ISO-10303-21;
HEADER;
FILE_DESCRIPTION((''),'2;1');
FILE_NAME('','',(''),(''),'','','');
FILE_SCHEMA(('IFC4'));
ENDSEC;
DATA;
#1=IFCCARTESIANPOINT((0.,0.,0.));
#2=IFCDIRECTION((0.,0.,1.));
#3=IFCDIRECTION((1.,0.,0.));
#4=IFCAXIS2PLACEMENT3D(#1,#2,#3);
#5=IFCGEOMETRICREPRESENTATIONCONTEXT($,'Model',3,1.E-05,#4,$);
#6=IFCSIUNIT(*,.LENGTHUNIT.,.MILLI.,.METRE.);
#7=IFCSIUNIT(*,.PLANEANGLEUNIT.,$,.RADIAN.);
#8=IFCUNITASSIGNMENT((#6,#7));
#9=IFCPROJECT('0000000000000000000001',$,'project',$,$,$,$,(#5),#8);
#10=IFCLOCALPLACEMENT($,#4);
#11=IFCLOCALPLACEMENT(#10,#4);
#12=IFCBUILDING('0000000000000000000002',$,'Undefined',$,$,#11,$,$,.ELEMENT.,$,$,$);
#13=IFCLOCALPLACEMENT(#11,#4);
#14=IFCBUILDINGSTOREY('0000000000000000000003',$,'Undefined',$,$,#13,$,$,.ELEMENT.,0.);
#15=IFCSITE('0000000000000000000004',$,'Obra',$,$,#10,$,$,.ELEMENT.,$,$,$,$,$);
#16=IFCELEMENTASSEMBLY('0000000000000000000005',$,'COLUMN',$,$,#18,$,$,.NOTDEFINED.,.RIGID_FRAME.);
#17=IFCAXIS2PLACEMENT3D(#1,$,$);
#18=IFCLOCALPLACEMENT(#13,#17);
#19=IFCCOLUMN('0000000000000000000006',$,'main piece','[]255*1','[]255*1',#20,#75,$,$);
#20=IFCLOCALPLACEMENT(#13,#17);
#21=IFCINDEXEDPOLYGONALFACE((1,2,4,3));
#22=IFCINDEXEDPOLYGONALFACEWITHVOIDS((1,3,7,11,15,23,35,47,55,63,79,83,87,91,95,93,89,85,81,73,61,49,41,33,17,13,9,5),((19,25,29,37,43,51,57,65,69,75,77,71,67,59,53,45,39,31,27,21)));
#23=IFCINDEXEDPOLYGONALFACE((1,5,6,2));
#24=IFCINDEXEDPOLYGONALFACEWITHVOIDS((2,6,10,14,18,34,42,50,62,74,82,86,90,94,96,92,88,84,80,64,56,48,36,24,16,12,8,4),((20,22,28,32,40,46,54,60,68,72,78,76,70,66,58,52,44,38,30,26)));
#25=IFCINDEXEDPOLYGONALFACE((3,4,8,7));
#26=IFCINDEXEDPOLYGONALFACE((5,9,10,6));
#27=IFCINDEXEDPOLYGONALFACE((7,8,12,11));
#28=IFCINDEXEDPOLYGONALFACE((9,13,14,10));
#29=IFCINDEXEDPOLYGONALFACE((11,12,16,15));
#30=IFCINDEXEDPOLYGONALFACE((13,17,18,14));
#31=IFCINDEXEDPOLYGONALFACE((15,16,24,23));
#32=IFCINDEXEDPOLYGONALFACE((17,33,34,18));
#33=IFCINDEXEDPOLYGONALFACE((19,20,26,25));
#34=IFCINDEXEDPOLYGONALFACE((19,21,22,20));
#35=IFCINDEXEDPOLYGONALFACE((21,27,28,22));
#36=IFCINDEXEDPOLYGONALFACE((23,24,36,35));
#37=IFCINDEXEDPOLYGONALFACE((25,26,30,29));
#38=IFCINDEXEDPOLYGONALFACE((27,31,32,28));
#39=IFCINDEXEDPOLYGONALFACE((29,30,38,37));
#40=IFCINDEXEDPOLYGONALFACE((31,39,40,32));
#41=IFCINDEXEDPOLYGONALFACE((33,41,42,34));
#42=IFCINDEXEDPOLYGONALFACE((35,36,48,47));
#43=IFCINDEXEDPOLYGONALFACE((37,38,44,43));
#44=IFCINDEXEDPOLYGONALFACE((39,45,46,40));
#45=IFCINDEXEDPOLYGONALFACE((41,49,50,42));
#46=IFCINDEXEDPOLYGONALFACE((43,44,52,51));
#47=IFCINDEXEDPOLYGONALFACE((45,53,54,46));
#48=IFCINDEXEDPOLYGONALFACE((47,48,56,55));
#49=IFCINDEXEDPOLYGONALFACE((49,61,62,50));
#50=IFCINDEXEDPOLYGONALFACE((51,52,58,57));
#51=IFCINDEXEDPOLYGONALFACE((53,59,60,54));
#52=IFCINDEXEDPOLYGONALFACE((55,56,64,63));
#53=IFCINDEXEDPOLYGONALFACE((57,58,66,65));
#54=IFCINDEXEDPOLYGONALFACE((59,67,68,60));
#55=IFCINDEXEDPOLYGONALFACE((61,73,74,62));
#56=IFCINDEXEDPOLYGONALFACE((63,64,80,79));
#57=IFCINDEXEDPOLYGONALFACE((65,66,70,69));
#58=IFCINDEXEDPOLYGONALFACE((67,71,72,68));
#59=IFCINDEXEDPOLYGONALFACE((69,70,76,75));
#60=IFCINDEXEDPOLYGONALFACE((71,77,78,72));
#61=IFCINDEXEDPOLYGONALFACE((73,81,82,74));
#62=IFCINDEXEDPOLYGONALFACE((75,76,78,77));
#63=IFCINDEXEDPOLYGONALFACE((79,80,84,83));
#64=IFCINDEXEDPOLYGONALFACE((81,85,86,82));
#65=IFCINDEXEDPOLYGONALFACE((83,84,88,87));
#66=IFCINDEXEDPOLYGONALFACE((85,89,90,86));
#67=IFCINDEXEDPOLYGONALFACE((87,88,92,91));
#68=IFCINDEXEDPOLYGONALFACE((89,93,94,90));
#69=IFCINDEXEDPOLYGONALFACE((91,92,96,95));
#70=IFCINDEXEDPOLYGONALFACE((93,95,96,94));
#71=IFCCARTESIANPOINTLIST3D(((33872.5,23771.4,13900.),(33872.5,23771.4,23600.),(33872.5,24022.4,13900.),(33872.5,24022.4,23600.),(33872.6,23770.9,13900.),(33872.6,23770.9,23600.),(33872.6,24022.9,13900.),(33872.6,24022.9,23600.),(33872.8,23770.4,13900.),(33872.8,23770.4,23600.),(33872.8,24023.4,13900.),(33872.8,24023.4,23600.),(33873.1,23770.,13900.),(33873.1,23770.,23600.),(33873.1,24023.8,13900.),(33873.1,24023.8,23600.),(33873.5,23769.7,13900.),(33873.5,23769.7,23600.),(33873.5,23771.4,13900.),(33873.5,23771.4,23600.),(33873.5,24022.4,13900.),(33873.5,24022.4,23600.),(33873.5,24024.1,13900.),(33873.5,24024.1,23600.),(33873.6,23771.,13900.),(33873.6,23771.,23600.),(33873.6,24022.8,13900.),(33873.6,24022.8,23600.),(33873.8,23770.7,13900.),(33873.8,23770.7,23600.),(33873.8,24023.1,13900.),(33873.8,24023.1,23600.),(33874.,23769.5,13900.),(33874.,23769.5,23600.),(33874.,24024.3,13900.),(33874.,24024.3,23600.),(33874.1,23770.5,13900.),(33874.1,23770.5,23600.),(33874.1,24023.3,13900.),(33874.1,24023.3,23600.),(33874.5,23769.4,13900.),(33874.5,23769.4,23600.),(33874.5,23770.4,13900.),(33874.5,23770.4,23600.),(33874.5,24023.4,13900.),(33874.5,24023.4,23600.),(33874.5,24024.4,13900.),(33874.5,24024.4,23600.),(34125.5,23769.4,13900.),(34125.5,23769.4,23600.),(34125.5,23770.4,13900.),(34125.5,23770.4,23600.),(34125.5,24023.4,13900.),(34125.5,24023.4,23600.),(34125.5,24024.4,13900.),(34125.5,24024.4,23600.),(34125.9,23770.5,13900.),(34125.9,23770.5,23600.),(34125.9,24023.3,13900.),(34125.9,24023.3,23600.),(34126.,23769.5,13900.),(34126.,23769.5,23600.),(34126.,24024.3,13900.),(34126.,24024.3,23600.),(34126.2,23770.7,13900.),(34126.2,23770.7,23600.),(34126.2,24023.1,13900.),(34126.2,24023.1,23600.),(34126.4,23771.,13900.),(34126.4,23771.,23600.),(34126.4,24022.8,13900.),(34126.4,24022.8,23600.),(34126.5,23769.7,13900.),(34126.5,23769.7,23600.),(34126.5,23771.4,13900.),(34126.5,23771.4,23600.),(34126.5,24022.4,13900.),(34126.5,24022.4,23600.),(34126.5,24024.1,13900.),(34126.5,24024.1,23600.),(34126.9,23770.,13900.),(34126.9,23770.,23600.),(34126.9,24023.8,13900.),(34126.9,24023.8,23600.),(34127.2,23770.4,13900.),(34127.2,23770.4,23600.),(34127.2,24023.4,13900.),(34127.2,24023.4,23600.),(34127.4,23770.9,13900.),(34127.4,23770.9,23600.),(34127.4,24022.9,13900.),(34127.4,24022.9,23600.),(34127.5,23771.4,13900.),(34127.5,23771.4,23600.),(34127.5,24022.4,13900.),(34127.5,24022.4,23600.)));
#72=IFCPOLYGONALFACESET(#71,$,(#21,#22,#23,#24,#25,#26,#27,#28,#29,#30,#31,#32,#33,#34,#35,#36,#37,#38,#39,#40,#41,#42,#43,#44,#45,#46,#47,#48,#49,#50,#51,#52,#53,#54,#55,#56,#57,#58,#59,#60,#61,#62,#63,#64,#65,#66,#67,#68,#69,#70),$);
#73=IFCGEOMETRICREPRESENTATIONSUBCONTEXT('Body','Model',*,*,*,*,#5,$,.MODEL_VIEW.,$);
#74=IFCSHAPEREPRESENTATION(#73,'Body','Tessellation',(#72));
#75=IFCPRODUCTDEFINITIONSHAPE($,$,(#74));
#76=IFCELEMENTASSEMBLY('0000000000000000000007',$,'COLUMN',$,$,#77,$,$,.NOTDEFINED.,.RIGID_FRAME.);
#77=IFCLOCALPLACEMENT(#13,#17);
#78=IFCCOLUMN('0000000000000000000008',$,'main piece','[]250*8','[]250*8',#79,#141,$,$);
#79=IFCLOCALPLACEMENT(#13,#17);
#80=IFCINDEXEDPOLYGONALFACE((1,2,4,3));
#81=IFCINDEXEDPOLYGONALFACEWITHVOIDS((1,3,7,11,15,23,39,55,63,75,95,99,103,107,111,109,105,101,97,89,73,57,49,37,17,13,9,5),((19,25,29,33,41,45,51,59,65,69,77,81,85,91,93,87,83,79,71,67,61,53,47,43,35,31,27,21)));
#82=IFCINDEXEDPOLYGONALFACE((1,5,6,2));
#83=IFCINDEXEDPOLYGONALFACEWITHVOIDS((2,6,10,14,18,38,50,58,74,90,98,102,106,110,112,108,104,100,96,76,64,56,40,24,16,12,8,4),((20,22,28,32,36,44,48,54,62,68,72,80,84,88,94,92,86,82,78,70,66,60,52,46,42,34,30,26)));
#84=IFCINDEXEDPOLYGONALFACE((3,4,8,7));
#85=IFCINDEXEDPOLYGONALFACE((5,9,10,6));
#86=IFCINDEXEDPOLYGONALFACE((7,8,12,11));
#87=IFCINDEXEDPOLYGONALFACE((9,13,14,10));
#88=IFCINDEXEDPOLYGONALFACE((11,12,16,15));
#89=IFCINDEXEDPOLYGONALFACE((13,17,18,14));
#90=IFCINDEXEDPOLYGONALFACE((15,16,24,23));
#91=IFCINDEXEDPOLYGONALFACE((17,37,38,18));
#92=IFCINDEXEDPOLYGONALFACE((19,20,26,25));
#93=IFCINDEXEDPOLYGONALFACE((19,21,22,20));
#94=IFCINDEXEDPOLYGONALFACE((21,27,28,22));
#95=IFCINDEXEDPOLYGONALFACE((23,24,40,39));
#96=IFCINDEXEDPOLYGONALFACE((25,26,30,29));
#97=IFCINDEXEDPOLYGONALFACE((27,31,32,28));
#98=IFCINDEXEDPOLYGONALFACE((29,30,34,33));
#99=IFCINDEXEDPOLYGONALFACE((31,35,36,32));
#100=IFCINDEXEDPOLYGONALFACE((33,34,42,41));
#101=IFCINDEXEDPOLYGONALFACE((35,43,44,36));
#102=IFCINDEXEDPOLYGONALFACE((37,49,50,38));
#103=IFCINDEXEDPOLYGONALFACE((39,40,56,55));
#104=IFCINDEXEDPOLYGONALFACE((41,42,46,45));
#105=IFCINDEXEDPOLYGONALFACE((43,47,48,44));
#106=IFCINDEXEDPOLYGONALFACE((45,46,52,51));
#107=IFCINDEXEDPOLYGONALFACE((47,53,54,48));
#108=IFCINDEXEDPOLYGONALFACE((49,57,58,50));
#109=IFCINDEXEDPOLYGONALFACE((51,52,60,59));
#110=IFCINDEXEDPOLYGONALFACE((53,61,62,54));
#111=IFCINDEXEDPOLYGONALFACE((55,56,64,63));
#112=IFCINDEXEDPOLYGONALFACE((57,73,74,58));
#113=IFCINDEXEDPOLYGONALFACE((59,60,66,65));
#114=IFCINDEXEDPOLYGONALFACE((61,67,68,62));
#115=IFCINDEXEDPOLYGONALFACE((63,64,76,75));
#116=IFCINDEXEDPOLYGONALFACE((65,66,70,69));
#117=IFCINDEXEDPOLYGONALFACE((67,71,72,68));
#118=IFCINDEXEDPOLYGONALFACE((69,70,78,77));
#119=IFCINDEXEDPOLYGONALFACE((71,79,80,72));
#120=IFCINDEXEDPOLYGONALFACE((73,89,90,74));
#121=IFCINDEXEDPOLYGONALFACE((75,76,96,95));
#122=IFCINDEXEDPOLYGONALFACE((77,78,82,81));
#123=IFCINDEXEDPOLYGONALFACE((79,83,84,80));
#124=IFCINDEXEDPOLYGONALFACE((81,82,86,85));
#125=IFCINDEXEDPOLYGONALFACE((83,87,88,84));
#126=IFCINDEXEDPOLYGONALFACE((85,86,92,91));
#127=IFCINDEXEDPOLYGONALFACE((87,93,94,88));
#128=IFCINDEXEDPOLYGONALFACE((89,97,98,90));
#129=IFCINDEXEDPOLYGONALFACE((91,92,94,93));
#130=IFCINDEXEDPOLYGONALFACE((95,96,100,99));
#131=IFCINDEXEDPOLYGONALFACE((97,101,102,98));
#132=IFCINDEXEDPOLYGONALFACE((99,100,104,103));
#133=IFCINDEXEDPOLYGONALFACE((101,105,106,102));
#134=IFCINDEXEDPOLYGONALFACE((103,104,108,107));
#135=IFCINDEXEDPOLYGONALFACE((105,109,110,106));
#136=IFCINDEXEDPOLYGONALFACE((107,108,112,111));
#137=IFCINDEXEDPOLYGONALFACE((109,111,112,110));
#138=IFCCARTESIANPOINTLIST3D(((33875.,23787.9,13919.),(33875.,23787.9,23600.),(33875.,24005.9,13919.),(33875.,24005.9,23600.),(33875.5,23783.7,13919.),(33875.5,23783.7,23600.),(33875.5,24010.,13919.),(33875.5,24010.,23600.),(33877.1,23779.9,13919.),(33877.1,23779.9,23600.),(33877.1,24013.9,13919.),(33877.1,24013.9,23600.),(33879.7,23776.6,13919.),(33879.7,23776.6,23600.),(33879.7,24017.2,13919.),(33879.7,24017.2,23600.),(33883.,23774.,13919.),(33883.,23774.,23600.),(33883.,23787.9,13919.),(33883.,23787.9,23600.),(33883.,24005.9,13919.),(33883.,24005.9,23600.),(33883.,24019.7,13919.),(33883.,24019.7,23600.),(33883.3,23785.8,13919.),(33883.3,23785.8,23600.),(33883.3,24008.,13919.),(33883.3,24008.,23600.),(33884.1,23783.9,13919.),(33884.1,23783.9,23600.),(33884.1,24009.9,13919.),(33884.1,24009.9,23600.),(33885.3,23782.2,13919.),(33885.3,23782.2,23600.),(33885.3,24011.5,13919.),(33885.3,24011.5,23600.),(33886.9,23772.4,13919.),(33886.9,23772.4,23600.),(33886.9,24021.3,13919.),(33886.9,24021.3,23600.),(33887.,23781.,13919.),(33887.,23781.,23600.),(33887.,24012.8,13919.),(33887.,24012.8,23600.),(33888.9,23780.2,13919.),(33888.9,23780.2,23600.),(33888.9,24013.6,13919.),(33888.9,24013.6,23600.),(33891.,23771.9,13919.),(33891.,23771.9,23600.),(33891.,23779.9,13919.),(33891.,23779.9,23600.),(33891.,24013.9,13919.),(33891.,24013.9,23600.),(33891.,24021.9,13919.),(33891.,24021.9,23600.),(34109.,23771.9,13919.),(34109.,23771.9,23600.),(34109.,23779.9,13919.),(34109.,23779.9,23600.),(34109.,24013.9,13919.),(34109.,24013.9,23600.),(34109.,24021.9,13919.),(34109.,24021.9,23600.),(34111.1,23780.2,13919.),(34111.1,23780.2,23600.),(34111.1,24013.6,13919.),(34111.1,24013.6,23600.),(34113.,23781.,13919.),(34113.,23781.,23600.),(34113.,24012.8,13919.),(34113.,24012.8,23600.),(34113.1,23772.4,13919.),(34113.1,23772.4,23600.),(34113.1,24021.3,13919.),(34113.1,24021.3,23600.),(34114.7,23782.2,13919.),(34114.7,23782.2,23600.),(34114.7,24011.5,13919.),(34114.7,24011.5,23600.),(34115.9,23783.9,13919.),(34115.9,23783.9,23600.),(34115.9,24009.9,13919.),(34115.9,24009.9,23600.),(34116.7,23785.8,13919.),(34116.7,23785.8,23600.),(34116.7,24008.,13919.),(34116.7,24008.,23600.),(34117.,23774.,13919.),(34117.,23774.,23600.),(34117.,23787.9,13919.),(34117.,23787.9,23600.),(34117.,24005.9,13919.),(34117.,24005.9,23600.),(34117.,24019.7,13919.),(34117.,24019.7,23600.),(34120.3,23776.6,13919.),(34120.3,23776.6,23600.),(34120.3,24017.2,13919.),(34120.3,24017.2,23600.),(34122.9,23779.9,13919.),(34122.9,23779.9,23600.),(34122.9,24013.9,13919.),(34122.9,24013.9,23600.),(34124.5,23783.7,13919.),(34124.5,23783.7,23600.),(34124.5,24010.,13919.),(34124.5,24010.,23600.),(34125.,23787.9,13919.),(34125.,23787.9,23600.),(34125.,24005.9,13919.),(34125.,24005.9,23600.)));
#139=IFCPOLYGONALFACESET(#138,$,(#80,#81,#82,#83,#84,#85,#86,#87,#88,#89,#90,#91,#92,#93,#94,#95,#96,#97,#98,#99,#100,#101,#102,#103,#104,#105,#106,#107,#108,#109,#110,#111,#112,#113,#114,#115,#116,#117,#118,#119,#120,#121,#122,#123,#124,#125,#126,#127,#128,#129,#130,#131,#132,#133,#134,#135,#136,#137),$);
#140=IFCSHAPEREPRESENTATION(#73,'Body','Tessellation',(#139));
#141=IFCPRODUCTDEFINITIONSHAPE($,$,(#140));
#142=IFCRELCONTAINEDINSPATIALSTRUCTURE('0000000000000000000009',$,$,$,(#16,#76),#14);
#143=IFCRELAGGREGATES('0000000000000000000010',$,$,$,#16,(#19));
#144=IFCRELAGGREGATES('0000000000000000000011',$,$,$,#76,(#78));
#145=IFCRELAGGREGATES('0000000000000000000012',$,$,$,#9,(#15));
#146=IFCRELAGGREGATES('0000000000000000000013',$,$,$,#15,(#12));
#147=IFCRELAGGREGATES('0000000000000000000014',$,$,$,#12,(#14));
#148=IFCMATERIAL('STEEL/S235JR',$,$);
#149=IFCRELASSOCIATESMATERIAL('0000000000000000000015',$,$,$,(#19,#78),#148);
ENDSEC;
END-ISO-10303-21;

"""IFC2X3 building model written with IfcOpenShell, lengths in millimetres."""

from ifc_helpers import new_model, si_unit, frame, origin_with_axes, origin_2d_with_axis, place, context, subcontext, project, spatial, hollow_rectangle, extrude, clip, halfspace, material, element, aggregate, save


model = new_model("IFC2X3")

# Units and contexts
model_context = context("Model", 3, precision=1e-05, world=origin_with_axes())
body_context = subcontext(model_context, "Body", "Model", "MODEL_VIEW")
ifc_project = project(units=[si_unit("LENGTHUNIT", "METRE", prefix="MILLI"), si_unit("PLANEANGLEUNIT", "RADIAN")], contexts=[model_context])

# Site, building, storey
site_placement = place(None, origin_with_axes())
site = spatial("IfcSite", under=ifc_project, at=site_placement, Name="Obra", CompositionType="ELEMENT")
building_placement = place(site_placement, origin_with_axes())
building = spatial("IfcBuilding", under=site, at=building_placement, Name="Undefined", CompositionType="ELEMENT")
storey_placement = place(building_placement, origin_with_axes())
storey = spatial("IfcBuildingStorey", under=building, at=storey_placement, Name="Undefined", CompositionType="ELEMENT", Elevation=0.0)

# Element assemblies, columns
assembly_1_placement = place(storey_placement, origin_with_axes())
assembly_1 = element("IfcElementAssembly", 1, at=assembly_1_placement, inside=storey, Name="COLUMN", AssemblyPlace="NOTDEFINED", PredefinedType="RIGID_FRAME")
ifc_material_1 = material(Name="STEEL/S235JR")
column_1_placement = place(assembly_1_placement, frame((34000.0, 23896.9, 13900.0), z_axis=(0.0, 0.0, 1.0), x_axis=(0.0, 1.0, 0.0)))
column_1 = element("IfcColumn", 2, at=column_1_placement, material=ifc_material_1, Name="main piece", Description="[]255*1", ObjectType="[]255*1", context=body_context, shape_type="SweptSolid", body=[
    extrude(hollow_rectangle(XDim=255.0, YDim=255.0, WallThickness=1.0, InnerFilletRadius=1.0, OuterFilletRadius=2.0, at=origin_2d_with_axis()), frame((0.0, 0.0, 9700.0), z_axis=(0.0, 0.0, -1.0), x_axis=(0.0, 1.0, 0.0)), (0.0, 0.0, 1.0), 9700.0),
])
assembly_2_placement = place(storey_placement, origin_with_axes())
assembly_2 = element("IfcElementAssembly", 3, at=assembly_2_placement, inside=storey, Name="COLUMN", AssemblyPlace="NOTDEFINED", PredefinedType="RIGID_FRAME")
column_2_placement = place(assembly_2_placement, frame((34000.0, 23896.9, 13900.0), z_axis=(0.0, 0.0, 1.0), x_axis=(0.0, 1.0, 0.0)))
column_2 = element("IfcColumn", 4, at=column_2_placement, material=ifc_material_1, Name="main piece", Description="[]250*8", ObjectType="[]250*8", context=body_context, shape_type="Clipping", body=[
    clip(extrude(hollow_rectangle(XDim=250.0, YDim=250.0, WallThickness=8.0, InnerFilletRadius=8.0, OuterFilletRadius=16.0, at=origin_2d_with_axis()), frame((0.0, 0.0, 9700.0), z_axis=(0.0, 0.0, -1.0), x_axis=(0.0, 1.0, 0.0)), (0.0, 0.0, 1.0), 9681.0), halfspace(frame((-125.0, 0.0, 19.0), z_axis=(0.0, 0.0, 1.0), x_axis=(0.0, 1.0, 0.0)), True)),
])

aggregate(assembly_1, [column_1])

aggregate(assembly_2, [column_2])

save(model, "model.ifc")
